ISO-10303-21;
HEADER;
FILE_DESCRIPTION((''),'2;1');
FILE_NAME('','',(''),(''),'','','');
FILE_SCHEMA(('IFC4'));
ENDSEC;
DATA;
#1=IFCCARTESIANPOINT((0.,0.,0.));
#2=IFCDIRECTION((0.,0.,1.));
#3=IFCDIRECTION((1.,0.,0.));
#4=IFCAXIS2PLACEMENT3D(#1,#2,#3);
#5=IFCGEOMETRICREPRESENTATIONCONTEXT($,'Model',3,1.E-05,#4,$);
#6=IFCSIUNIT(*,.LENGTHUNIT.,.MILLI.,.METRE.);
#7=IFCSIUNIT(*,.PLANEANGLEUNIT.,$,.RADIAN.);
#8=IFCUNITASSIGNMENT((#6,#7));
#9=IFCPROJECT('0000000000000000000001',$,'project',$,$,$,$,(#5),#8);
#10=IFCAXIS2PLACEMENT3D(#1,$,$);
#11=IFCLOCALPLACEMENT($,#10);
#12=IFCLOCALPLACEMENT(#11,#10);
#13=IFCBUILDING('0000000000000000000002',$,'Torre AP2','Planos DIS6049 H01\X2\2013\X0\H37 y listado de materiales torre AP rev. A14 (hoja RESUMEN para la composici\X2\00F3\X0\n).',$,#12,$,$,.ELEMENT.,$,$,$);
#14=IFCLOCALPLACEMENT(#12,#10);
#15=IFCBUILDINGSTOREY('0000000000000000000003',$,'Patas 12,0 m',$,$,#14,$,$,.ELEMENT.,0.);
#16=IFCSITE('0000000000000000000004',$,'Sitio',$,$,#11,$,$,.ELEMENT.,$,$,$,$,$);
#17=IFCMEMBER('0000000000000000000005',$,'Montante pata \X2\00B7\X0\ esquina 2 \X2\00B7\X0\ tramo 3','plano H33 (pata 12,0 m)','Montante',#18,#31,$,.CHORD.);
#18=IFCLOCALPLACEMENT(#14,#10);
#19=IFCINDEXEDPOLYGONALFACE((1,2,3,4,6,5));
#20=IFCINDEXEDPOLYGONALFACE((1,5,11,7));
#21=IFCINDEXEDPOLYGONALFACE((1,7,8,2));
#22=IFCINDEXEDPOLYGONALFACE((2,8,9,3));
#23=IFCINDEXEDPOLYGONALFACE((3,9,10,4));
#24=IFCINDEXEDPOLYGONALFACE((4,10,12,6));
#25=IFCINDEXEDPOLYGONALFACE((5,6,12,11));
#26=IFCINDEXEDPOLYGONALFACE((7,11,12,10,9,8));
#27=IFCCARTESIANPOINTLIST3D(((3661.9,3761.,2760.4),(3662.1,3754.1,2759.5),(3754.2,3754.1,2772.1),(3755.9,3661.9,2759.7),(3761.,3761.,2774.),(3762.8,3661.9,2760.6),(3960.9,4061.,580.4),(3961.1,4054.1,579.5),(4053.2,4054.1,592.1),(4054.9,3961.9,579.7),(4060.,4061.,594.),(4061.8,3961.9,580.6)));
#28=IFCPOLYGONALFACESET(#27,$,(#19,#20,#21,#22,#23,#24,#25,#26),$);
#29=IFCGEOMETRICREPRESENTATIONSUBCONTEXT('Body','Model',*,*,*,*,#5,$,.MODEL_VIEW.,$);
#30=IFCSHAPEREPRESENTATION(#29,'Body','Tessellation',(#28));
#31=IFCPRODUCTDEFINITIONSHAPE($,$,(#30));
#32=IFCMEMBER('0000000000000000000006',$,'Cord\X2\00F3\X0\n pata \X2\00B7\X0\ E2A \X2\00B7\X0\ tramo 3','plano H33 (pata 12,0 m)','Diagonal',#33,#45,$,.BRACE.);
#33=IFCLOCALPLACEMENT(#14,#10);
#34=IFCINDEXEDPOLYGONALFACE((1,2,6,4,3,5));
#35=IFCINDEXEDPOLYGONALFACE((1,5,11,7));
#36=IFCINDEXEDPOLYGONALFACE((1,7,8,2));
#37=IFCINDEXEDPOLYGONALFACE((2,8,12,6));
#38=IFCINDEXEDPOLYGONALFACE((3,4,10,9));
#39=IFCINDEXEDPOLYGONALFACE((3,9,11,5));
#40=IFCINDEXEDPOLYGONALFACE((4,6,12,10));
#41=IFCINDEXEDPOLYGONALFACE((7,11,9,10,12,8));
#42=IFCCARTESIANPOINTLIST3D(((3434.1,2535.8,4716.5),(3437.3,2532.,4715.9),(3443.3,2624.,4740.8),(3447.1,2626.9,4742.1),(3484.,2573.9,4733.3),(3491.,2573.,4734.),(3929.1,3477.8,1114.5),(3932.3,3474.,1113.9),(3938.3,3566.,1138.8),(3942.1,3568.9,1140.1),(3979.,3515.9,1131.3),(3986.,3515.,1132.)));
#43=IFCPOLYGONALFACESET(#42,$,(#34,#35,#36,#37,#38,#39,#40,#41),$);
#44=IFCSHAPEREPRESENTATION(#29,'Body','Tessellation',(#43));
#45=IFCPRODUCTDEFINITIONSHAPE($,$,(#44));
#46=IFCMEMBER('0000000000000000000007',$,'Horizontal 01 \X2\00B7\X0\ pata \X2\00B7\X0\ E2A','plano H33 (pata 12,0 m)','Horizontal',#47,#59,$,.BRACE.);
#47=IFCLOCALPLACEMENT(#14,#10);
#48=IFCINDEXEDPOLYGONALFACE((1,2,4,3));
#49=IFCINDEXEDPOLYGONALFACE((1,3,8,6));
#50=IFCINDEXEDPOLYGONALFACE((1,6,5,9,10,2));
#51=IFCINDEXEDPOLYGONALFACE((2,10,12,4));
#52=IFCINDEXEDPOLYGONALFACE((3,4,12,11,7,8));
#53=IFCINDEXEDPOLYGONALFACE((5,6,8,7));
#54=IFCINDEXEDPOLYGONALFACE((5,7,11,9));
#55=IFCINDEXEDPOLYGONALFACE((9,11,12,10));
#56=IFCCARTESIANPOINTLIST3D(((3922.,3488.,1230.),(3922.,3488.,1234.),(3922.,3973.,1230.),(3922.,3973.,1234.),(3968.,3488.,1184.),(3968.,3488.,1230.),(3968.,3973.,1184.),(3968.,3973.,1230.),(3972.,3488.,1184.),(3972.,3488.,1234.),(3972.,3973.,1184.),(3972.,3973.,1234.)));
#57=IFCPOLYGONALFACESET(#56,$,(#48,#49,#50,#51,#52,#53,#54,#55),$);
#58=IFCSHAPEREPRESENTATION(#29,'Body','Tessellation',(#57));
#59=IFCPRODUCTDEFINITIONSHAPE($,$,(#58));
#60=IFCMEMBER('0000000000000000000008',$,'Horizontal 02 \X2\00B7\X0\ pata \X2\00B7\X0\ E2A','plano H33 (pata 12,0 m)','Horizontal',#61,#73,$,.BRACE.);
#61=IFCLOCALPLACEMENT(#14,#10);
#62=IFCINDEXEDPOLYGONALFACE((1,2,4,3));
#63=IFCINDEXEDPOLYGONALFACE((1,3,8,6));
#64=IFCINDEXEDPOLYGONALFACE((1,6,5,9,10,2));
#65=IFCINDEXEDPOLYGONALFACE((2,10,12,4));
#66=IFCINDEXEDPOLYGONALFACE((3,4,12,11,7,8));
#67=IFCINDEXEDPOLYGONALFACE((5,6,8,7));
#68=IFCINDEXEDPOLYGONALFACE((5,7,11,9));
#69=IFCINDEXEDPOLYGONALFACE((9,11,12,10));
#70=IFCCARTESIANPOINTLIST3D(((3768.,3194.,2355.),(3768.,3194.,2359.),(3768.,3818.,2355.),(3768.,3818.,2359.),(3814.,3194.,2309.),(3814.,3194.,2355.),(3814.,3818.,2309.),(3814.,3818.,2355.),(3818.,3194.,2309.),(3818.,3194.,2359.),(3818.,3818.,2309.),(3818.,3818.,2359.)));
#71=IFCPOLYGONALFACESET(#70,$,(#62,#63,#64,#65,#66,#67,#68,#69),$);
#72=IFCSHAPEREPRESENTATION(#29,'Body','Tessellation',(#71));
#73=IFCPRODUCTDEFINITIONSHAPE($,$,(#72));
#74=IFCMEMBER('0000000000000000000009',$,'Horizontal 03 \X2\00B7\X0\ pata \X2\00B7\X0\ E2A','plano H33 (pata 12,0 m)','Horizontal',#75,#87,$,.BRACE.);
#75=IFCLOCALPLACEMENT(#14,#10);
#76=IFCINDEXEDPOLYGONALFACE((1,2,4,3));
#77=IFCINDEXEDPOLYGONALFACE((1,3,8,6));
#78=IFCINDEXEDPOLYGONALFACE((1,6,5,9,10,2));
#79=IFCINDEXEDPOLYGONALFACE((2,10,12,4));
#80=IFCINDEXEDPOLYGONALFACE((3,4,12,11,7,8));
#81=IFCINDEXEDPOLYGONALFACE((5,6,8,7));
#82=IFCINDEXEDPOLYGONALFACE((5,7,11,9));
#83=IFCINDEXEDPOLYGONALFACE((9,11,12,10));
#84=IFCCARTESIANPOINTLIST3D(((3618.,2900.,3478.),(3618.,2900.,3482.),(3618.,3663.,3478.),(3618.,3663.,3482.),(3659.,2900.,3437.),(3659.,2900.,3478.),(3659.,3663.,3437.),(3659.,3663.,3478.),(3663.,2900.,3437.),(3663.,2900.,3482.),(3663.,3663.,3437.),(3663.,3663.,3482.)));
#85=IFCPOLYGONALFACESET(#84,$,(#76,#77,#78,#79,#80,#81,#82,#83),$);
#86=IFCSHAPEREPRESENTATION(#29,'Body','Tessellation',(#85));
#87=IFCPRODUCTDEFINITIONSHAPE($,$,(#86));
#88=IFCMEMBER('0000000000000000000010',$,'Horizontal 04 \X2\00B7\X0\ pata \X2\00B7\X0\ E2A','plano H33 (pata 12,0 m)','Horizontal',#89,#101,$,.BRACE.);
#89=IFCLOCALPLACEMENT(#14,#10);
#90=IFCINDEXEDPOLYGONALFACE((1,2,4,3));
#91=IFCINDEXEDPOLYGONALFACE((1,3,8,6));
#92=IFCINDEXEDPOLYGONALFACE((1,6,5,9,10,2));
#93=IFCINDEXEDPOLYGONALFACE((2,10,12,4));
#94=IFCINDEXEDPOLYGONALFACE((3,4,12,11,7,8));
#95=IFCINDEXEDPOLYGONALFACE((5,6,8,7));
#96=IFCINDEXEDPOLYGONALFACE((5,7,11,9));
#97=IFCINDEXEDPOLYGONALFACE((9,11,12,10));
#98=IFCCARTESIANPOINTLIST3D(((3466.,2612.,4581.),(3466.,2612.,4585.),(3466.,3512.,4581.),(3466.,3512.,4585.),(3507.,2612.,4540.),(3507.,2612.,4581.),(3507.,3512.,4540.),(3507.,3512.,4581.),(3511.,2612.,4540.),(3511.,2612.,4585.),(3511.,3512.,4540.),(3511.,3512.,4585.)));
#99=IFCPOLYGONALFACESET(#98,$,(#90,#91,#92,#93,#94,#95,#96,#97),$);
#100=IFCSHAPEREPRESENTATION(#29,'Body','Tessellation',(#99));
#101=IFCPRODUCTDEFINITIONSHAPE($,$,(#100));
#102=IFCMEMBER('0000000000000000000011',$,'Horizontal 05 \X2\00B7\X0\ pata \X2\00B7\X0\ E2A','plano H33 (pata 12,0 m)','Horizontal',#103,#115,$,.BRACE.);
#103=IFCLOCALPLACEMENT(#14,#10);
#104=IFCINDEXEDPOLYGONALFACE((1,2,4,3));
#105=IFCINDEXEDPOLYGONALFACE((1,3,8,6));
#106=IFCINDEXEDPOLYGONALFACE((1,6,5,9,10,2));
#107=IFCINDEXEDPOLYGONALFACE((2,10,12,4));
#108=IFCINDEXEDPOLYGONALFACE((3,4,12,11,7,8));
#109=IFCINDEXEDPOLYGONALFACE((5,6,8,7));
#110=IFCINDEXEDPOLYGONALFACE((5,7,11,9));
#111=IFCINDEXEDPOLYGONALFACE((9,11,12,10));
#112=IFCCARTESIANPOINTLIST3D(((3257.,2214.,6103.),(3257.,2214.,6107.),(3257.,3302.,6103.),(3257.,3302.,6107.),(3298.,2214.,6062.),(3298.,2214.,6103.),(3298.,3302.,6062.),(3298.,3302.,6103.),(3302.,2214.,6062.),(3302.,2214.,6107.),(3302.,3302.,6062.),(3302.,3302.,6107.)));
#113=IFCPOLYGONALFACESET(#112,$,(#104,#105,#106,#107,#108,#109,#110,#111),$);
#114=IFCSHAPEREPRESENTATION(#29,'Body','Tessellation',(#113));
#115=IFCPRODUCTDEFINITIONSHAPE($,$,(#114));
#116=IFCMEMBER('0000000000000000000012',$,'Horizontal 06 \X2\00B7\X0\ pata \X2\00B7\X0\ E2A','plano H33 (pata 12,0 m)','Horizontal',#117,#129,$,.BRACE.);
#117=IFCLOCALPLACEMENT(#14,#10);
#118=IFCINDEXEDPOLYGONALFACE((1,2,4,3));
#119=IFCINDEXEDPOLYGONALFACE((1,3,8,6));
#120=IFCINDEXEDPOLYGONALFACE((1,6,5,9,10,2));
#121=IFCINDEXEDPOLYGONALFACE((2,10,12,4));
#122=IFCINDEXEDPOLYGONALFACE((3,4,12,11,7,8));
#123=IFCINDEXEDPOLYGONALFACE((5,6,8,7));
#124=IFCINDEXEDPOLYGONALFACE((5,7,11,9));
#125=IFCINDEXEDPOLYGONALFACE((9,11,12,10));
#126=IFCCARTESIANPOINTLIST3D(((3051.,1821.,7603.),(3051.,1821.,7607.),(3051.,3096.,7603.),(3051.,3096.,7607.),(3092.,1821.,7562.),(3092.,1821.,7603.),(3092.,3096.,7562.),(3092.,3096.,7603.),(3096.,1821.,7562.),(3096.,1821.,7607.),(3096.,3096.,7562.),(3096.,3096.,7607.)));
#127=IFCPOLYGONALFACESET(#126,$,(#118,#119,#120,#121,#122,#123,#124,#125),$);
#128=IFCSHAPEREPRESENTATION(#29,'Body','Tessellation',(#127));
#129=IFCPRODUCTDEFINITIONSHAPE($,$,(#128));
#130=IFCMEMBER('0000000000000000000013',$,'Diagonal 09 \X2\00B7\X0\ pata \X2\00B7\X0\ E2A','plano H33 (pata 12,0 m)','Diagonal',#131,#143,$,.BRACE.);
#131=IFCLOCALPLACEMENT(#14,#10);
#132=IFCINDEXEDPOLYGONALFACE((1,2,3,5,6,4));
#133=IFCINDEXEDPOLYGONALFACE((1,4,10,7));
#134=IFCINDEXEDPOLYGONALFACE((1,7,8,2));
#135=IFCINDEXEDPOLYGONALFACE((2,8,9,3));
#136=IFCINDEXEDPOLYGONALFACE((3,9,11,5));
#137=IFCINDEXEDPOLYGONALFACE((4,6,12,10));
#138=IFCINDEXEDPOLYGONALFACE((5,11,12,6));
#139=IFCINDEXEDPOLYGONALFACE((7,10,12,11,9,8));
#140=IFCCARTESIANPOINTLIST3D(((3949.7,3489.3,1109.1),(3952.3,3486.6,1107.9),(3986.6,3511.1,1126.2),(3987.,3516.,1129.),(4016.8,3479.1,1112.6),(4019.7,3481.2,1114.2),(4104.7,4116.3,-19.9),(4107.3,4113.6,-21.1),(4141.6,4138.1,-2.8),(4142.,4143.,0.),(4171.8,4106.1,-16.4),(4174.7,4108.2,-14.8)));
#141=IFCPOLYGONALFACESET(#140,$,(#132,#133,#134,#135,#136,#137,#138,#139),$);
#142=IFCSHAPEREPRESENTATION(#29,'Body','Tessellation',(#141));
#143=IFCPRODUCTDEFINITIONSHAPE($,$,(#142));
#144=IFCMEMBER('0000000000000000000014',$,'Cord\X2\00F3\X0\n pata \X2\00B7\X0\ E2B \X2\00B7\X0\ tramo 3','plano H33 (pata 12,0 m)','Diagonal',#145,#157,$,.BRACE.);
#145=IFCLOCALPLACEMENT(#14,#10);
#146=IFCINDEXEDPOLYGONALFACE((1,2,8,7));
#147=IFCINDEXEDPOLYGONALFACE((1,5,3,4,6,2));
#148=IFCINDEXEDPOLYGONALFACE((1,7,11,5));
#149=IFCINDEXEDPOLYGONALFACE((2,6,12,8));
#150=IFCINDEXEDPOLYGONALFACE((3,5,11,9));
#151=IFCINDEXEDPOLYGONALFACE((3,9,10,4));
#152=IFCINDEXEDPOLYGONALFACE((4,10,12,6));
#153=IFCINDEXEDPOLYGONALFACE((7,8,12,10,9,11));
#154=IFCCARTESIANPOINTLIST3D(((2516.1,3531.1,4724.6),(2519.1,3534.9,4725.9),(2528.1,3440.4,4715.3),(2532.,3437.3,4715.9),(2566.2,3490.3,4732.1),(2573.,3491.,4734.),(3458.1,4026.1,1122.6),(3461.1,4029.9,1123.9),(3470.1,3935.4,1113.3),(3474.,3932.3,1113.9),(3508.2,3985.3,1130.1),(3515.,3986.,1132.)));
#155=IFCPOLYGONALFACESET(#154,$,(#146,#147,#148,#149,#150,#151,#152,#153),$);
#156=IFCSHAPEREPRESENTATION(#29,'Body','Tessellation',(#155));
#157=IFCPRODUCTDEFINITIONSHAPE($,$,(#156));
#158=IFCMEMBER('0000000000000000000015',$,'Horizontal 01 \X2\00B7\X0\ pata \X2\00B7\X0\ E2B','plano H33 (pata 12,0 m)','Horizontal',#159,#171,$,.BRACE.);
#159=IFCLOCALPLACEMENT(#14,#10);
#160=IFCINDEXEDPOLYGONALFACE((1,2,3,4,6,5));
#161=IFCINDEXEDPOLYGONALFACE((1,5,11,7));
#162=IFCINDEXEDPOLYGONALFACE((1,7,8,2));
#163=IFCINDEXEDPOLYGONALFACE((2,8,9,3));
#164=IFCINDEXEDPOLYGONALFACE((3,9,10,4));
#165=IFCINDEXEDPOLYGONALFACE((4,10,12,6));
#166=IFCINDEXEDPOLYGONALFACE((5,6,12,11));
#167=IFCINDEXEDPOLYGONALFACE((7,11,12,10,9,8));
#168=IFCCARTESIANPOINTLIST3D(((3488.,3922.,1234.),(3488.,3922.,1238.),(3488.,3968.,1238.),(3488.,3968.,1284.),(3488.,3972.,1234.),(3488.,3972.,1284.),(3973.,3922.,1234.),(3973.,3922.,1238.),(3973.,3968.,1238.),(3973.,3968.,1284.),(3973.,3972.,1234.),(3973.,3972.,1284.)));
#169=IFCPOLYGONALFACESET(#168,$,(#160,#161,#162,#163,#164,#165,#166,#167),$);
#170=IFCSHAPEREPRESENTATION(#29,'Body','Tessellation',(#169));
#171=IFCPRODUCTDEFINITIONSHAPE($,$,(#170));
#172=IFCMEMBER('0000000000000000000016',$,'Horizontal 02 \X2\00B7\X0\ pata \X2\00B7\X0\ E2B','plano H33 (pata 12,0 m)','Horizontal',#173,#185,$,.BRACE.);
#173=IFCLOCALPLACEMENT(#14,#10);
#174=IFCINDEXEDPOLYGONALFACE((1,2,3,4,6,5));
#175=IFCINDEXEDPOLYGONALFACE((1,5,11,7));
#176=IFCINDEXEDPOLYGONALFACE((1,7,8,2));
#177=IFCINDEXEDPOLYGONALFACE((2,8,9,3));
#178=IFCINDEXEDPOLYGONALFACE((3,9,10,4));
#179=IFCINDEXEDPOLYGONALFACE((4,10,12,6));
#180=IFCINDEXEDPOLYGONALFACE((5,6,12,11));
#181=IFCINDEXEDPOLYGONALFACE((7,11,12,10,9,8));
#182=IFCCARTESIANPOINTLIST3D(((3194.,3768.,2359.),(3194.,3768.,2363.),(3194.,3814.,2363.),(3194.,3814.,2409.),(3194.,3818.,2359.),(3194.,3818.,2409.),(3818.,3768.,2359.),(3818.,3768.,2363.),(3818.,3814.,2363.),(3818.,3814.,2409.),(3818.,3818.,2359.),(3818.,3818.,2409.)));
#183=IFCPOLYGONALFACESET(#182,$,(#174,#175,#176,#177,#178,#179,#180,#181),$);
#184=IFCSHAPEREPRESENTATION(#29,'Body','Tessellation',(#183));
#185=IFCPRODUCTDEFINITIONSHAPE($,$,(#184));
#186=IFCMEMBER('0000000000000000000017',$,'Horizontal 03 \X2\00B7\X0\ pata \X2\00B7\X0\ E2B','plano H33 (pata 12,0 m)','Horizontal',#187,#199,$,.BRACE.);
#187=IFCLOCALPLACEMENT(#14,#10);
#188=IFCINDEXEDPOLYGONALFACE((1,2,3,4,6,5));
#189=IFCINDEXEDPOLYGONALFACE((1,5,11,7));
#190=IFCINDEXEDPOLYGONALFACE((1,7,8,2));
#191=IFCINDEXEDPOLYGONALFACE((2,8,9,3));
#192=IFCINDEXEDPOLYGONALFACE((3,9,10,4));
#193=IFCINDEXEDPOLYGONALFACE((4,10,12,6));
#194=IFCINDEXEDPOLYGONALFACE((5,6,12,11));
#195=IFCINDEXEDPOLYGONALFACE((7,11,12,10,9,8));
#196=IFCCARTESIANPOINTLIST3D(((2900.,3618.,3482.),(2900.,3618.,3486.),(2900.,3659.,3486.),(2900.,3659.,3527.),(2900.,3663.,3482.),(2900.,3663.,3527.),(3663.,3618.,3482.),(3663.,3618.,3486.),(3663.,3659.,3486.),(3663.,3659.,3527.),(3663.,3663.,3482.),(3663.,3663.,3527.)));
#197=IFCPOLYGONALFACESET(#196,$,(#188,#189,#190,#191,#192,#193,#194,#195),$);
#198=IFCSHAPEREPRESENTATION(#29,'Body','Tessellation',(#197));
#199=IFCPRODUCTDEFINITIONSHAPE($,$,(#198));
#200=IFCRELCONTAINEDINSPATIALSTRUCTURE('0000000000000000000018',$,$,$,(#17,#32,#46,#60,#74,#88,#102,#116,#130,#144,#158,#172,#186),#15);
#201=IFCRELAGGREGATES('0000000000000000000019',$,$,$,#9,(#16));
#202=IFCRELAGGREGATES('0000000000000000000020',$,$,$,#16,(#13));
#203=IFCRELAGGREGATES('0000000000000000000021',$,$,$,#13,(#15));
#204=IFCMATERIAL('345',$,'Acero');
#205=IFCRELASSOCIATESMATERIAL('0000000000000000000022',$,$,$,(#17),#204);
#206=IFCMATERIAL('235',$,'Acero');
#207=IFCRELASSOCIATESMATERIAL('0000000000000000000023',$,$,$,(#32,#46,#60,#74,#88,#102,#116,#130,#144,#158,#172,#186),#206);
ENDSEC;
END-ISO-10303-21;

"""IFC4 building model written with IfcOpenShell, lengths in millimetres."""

from ifc_helpers import new_model, si_unit, frame, frame_2d, origin, origin_with_axes, place, context, subcontext, project, spatial, l_section, extrude, material, element, save


model = new_model("IFC4")

# Units and contexts
model_context = context("Model", 3, precision=1e-05, world=origin_with_axes())
body_context = subcontext(model_context, "Body", "Model", "MODEL_VIEW")
ifc_project = project(units=[si_unit("LENGTHUNIT", "METRE", prefix="MILLI"), si_unit("PLANEANGLEUNIT", "RADIAN")], contexts=[model_context])

# Site, building, storey
site_placement = place(None, origin())
site = spatial("IfcSite", under=ifc_project, at=site_placement, Name="Sitio", CompositionType="ELEMENT")
building_placement = place(site_placement, origin())
building = spatial("IfcBuilding", under=site, at=building_placement, Name="Torre AP2", Description="Planos DIS6049 H01–H37 y listado de materiales torre AP rev. A14 (hoja RESUMEN para la composición).", CompositionType="ELEMENT")
storey_placement = place(building_placement, origin())
storey = spatial("IfcBuildingStorey", under=building, at=storey_placement, Name="Patas 12,0 m", CompositionType="ELEMENT", Elevation=0.0)

# Members
ifc_material_1 = material(Name="345", Category="Acero")
member_1_placement = place(storey_placement, frame((3761.0, 3761.0, 2774.0), z_axis=(0.134638, 0.135089, -0.981643), x_axis=(0.018356, -0.990834, -0.133836)))
element("IfcMember", 1, at=member_1_placement, inside=storey, material=ifc_material_1, Name="Montante pata · esquina 2 · tramo 3", Description="plano H33 (pata 12,0 m)", ObjectType="Montante", PredefinedType="CHORD", context=body_context, shape_type="SweptSolid", body=[
    extrude(l_section(Depth=100.0, Width=100.0, Thickness=7.0, at=frame_2d((50.0, 50.0))), None, (0.0, 0.0, 1.0), 2220.8),
])
ifc_material_2 = material(Name="235", Category="Acero")
member_2_placement = place(storey_placement, frame((3491.0, 2573.0, 4734.0), z_axis=(0.131793, 0.250805, -0.959024), x_axis=(-0.767633, -0.586303, -0.258822)))
element("IfcMember", 2, at=member_2_placement, inside=storey, material=ifc_material_2, Name="Cordón pata · E2A · tramo 3", Description="plano H33 (pata 12,0 m)", ObjectType="Diagonal", PredefinedType="BRACE", context=body_context, shape_type="SweptSolid", body=[
    extrude(l_section(Depth=70.0, Width=70.0, Thickness=5.0, at=frame_2d((35.0, 35.0))), None, (0.0, 0.0, 1.0), 3755.9),
])
member_3_placement = place(storey_placement, frame((3972.0, 3973.0, 1234.0), z_axis=(0.0, -1.0, 0.0), x_axis=(-1.0, 0.0, 0.0)))
element("IfcMember", 3, at=member_3_placement, inside=storey, material=ifc_material_2, Name="Horizontal 01 · pata · E2A", Description="plano H33 (pata 12,0 m)", ObjectType="Horizontal", PredefinedType="BRACE", context=body_context, shape_type="SweptSolid", body=[
    extrude(l_section(Depth=50.0, Width=50.0, Thickness=4.0, at=frame_2d((25.0, 25.0))), None, (0.0, 0.0, 1.0), 485.0),
])
member_4_placement = place(storey_placement, frame((3818.0, 3818.0, 2359.0), z_axis=(0.0, -1.0, 0.0), x_axis=(-1.0, 0.0, 0.0)))
element("IfcMember", 4, at=member_4_placement, inside=storey, material=ifc_material_2, Name="Horizontal 02 · pata · E2A", Description="plano H33 (pata 12,0 m)", ObjectType="Horizontal", PredefinedType="BRACE", context=body_context, shape_type="SweptSolid", body=[
    extrude(l_section(Depth=50.0, Width=50.0, Thickness=4.0, at=frame_2d((25.0, 25.0))), None, (0.0, 0.0, 1.0), 624.0),
])
member_5_placement = place(storey_placement, frame((3663.0, 3663.0, 3482.0), z_axis=(0.0, -1.0, 0.0), x_axis=(-1.0, 0.0, 0.0)))
element("IfcMember", 5, at=member_5_placement, inside=storey, material=ifc_material_2, Name="Horizontal 03 · pata · E2A", Description="plano H33 (pata 12,0 m)", ObjectType="Horizontal", PredefinedType="BRACE", context=body_context, shape_type="SweptSolid", body=[
    extrude(l_section(Depth=45.0, Width=45.0, Thickness=4.0, at=frame_2d((22.5, 22.5))), None, (0.0, 0.0, 1.0), 763.0),
])
member_6_placement = place(storey_placement, frame((3511.0, 3512.0, 4585.0), z_axis=(0.0, -1.0, 0.0), x_axis=(-1.0, 0.0, 0.0)))
element("IfcMember", 6, at=member_6_placement, inside=storey, material=ifc_material_2, Name="Horizontal 04 · pata · E2A", Description="plano H33 (pata 12,0 m)", ObjectType="Horizontal", PredefinedType="BRACE", context=body_context, shape_type="SweptSolid", body=[
    extrude(l_section(Depth=45.0, Width=45.0, Thickness=4.0, at=frame_2d((22.5, 22.5))), None, (0.0, 0.0, 1.0), 900.0),
])
member_7_placement = place(storey_placement, frame((3302.0, 3302.0, 6107.0), z_axis=(0.0, -1.0, 0.0), x_axis=(-1.0, 0.0, 0.0)))
element("IfcMember", 7, at=member_7_placement, inside=storey, material=ifc_material_2, Name="Horizontal 05 · pata · E2A", Description="plano H33 (pata 12,0 m)", ObjectType="Horizontal", PredefinedType="BRACE", context=body_context, shape_type="SweptSolid", body=[
    extrude(l_section(Depth=45.0, Width=45.0, Thickness=4.0, at=frame_2d((22.5, 22.5))), None, (0.0, 0.0, 1.0), 1088.0),
])
member_8_placement = place(storey_placement, frame((3096.0, 3096.0, 7607.0), z_axis=(0.0, -1.0, 0.0), x_axis=(-1.0, 0.0, 0.0)))
element("IfcMember", 8, at=member_8_placement, inside=storey, material=ifc_material_2, Name="Horizontal 06 · pata · E2A", Description="plano H33 (pata 12,0 m)", ObjectType="Horizontal", PredefinedType="BRACE", context=body_context, shape_type="SweptSolid", body=[
    extrude(l_section(Depth=45.0, Width=45.0, Thickness=4.0, at=frame_2d((22.5, 22.5))), None, (0.0, 0.0, 1.0), 1275.0),
])
member_9_placement = place(storey_placement, frame((4142.0, 4143.0, 0.0), z_axis=(-0.119168, -0.482052, 0.868001), x_axis=(-0.746182, -0.53324, -0.398583)))
element("IfcMember", 9, at=member_9_placement, inside=storey, material=ifc_material_2, Name="Diagonal 09 · pata · E2A", Description="plano H33 (pata 12,0 m)", ObjectType="Diagonal", PredefinedType="BRACE", context=body_context, shape_type="SweptSolid", body=[
    extrude(l_section(Depth=50.0, Width=50.0, Thickness=4.0, at=frame_2d((25.0, 25.0))), None, (0.0, 0.0, 1.0), 1300.7),
])
member_10_placement = place(storey_placement, frame((2573.0, 3491.0, 4734.0), z_axis=(0.250805, 0.131793, -0.959024), x_axis=(-0.586303, -0.767633, -0.258822)))
element("IfcMember", 10, at=member_10_placement, inside=storey, material=ifc_material_2, Name="Cordón pata · E2B · tramo 3", Description="plano H33 (pata 12,0 m)", ObjectType="Diagonal", PredefinedType="BRACE", context=body_context, shape_type="SweptSolid", body=[
    extrude(l_section(Depth=70.0, Width=70.0, Thickness=5.0, at=frame_2d((35.0, 35.0))), None, (0.0, 0.0, 1.0), 3755.9),
])
member_11_placement = place(storey_placement, frame((3973.0, 3972.0, 1234.0), z_axis=(-1.0, 0.0, 0.0), x_axis=(0.0, -1.0, 0.0)))
element("IfcMember", 11, at=member_11_placement, inside=storey, material=ifc_material_2, Name="Horizontal 01 · pata · E2B", Description="plano H33 (pata 12,0 m)", ObjectType="Horizontal", PredefinedType="BRACE", context=body_context, shape_type="SweptSolid", body=[
    extrude(l_section(Depth=50.0, Width=50.0, Thickness=4.0, at=frame_2d((25.0, 25.0))), None, (0.0, 0.0, 1.0), 485.0),
])
member_12_placement = place(storey_placement, frame((3818.0, 3818.0, 2359.0), z_axis=(-1.0, 0.0, 0.0), x_axis=(0.0, -1.0, 0.0)))
element("IfcMember", 12, at=member_12_placement, inside=storey, material=ifc_material_2, Name="Horizontal 02 · pata · E2B", Description="plano H33 (pata 12,0 m)", ObjectType="Horizontal", PredefinedType="BRACE", context=body_context, shape_type="SweptSolid", body=[
    extrude(l_section(Depth=50.0, Width=50.0, Thickness=4.0, at=frame_2d((25.0, 25.0))), None, (0.0, 0.0, 1.0), 624.0),
])
member_13_placement = place(storey_placement, frame((3663.0, 3663.0, 3482.0), z_axis=(-1.0, 0.0, 0.0), x_axis=(0.0, -1.0, 0.0)))
element("IfcMember", 13, at=member_13_placement, inside=storey, material=ifc_material_2, Name="Horizontal 03 · pata · E2B", Description="plano H33 (pata 12,0 m)", ObjectType="Horizontal", PredefinedType="BRACE", context=body_context, shape_type="SweptSolid", body=[
    extrude(l_section(Depth=45.0, Width=45.0, Thickness=4.0, at=frame_2d((22.5, 22.5))), None, (0.0, 0.0, 1.0), 763.0),
])

save(model, "model.ifc")
